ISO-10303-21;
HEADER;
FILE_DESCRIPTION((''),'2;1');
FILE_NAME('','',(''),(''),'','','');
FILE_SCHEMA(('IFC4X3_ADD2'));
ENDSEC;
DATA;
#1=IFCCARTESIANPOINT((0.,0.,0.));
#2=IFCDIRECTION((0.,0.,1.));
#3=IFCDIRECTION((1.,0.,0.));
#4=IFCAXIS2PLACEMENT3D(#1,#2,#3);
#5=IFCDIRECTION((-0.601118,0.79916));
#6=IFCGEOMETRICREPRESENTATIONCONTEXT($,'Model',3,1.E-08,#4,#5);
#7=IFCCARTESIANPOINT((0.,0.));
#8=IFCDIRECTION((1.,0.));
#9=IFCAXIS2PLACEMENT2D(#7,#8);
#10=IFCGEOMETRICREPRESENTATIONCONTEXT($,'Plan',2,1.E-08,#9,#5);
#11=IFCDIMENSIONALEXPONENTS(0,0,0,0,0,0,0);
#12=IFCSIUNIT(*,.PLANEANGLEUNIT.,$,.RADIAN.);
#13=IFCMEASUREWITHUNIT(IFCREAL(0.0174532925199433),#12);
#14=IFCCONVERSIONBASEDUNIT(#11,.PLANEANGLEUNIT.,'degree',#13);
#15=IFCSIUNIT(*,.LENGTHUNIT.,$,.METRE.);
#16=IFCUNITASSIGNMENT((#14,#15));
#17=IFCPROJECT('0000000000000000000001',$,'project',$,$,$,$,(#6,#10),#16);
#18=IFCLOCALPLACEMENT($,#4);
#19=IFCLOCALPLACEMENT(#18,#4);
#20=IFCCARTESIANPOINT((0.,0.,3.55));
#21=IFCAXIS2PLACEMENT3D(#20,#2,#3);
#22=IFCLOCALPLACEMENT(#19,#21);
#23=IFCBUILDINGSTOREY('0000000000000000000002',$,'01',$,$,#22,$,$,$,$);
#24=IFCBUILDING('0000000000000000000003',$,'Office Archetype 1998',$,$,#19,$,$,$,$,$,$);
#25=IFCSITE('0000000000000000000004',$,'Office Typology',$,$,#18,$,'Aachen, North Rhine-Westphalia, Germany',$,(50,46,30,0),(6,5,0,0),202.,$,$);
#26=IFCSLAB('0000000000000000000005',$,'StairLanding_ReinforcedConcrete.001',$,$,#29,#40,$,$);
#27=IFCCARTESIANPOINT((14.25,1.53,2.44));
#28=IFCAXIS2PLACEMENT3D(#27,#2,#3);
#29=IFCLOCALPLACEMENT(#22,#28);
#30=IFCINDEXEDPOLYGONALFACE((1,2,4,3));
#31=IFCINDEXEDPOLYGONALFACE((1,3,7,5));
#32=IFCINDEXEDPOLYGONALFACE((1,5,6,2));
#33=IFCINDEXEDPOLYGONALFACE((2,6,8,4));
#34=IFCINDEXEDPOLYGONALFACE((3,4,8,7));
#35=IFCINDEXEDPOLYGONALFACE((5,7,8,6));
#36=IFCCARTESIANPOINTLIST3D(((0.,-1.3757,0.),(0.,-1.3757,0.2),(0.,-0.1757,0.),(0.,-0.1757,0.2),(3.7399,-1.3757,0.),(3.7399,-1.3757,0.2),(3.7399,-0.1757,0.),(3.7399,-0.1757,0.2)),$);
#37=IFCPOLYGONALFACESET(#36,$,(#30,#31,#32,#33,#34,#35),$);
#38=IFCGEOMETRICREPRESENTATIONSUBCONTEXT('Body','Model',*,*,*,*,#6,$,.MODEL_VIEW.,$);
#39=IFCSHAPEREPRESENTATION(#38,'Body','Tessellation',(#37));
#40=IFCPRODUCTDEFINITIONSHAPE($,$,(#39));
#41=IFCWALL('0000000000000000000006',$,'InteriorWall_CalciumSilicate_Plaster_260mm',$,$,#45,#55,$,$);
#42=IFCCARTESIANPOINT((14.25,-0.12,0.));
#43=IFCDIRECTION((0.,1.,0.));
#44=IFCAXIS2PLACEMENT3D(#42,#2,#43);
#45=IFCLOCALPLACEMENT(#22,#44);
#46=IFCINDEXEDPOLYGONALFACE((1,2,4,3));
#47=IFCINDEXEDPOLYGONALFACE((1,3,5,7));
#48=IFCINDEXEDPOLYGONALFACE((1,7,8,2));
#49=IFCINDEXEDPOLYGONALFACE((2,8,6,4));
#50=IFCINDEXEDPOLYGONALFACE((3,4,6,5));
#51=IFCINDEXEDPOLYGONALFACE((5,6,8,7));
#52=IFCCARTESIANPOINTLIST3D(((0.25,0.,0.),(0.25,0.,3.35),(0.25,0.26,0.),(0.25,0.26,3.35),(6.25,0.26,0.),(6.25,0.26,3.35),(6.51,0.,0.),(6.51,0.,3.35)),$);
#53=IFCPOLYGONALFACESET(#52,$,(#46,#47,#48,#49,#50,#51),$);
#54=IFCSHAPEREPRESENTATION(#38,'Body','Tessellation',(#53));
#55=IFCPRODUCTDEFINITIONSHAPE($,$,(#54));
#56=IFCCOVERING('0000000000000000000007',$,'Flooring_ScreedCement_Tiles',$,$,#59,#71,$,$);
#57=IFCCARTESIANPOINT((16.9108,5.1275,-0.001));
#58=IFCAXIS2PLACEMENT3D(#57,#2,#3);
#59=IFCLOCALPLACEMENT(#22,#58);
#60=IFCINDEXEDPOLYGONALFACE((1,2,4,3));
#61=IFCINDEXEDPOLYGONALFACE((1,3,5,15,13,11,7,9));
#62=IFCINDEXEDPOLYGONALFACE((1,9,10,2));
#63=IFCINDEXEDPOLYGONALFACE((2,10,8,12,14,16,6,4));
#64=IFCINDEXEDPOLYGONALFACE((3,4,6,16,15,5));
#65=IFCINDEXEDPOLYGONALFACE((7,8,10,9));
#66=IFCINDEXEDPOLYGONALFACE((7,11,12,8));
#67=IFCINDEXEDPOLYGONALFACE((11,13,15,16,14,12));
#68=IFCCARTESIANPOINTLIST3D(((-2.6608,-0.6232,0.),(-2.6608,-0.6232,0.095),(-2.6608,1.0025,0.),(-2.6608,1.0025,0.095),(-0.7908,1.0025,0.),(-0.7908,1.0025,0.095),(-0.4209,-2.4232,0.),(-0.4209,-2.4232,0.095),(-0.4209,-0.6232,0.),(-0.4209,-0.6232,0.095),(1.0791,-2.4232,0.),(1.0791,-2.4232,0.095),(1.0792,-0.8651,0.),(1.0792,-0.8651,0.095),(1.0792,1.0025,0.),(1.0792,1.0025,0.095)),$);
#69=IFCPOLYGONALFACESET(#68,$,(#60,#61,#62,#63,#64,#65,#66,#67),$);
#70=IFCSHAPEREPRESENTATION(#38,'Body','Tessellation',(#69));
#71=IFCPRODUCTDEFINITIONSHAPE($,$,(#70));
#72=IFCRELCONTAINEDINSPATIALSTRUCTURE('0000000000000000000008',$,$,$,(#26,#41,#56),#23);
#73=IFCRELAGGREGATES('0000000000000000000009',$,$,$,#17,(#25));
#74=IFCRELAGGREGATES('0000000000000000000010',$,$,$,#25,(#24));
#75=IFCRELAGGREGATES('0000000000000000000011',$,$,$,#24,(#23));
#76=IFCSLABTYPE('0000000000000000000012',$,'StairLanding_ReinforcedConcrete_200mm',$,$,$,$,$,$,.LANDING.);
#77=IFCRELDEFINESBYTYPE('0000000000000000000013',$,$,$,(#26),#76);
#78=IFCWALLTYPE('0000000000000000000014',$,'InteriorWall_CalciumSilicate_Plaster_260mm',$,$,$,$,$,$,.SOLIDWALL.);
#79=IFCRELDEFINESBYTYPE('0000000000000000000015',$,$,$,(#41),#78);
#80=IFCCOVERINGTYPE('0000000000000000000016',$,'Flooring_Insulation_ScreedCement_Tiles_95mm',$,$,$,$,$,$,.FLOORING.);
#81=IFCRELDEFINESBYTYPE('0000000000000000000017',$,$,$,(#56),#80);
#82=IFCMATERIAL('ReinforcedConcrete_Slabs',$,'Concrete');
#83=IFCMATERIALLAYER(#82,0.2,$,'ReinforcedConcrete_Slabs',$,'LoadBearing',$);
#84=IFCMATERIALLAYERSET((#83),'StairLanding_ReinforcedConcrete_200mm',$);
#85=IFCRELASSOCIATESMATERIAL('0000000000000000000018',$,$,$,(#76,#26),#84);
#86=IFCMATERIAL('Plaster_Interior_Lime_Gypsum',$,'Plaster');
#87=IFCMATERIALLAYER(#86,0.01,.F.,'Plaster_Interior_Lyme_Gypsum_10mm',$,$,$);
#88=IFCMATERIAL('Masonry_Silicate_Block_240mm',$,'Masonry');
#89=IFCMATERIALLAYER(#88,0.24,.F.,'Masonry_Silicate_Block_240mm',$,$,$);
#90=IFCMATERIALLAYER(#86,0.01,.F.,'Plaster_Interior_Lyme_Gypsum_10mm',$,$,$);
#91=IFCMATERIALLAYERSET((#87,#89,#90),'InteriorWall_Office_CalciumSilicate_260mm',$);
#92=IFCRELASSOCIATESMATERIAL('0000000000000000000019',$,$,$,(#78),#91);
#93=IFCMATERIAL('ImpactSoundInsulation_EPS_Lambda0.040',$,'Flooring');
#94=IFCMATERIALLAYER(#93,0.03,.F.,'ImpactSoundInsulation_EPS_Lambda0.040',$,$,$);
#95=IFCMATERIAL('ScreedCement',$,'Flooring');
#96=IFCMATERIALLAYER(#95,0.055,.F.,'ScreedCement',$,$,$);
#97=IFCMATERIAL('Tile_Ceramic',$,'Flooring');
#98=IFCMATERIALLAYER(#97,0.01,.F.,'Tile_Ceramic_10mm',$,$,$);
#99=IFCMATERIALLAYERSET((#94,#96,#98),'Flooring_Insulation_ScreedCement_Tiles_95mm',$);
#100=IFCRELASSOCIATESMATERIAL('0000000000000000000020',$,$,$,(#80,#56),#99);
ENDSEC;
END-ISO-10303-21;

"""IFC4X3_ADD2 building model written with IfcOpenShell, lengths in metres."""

from ifc_helpers import new_model, entity, si_unit, converted_unit, direction, frame, origin_with_axes, origin_2d_with_axis, place, context, subcontext, project, spatial, line, indexed_curve, outline, extrude, material, layer, layer_set, layer_usage, type_object, element, save


model = new_model("IFC4X3_ADD2")

# Units and contexts
model_context = context("Model", 3, precision=1e-08, world=origin_with_axes(), true_north=direction((-0.601118, 0.79916)))
plan_context = context("Plan", 2, precision=1e-08, world=origin_2d_with_axis(), true_north=direction((-0.601118, 0.79916)))
body_context = subcontext(model_context, "Body", "Model", "MODEL_VIEW")
ifc_project = project(units=[converted_unit("PLANEANGLEUNIT", "degree", entity("IfcReal", 0.0174532925199433), si_unit("PLANEANGLEUNIT", "RADIAN"), dimensions=[0, 0, 0, 0, 0, 0, 0]), si_unit("LENGTHUNIT", "METRE")], contexts=[model_context, plan_context])

# Site, building, storey
site_placement = place(None, origin_with_axes())
site = spatial("IfcSite", under=ifc_project, at=site_placement, Name="Office Typology", LongName="Aachen, North Rhine-Westphalia, Germany", RefLatitude=(50, 46, 30, 0), RefLongitude=(6, 5, 0, 0), RefElevation=202.0)
building_placement = place(site_placement, origin_with_axes())
building = spatial("IfcBuilding", under=site, at=building_placement, Name="Office Archetype 1998")
storey_placement = place(building_placement, frame((0.0, 0.0, 3.55), z_axis=(0.0, 0.0, 1.0), x_axis=(1.0, 0.0, 0.0)))
storey = spatial("IfcBuildingStorey", under=building, at=storey_placement, Name="01")

# Slab
ifc_material_1 = material(Name="ReinforcedConcrete_Slabs", Category="Concrete")
ifc_layer_1 = layer(ifc_material_1, 0.2, Name="ReinforcedConcrete_Slabs", Category="LoadBearing")
ifc_layer_set_1 = layer_set([ifc_layer_1], Name="StairLanding_ReinforcedConcrete_200mm")
ifc_layer_usage_1 = layer_usage(ifc_layer_set_1, "AXIS3", "POSITIVE", 0.0)
slab_type_1 = type_object("IfcSlabType", Name="StairLanding_ReinforcedConcrete_200mm", PredefinedType="LANDING", material=ifc_layer_set_1)
slab_1_placement = place(storey_placement, frame((14.25, 1.53, 2.44), z_axis=(0.0, 0.0, 1.0), x_axis=(1.0, 0.0, 0.0)))
element("IfcSlab", 1, at=slab_1_placement, inside=storey, type_object=slab_type_1, material=ifc_layer_usage_1, Name="StairLanding_ReinforcedConcrete.001", context=body_context, shape_type="SweptSolid", body=[
    extrude(outline(indexed_curve([(3.7399, -0.1757), (3.7399, -1.3757), (0.0, -1.3757), (0.0, -0.1757), (3.7399, -0.1757)])), None, (0.0, 0.0, 1.0), 0.2),
])

# Wall
ifc_material_2 = material(Name="Plaster_Interior_Lime_Gypsum", Category="Plaster")
ifc_layer_2 = layer(ifc_material_2, 0.01, ventilated=False, Name="Plaster_Interior_Lyme_Gypsum_10mm")
ifc_material_3 = material(Name="Masonry_Silicate_Block_240mm", Category="Masonry")
ifc_layer_3 = layer(ifc_material_3, 0.24, ventilated=False, Name="Masonry_Silicate_Block_240mm")
ifc_layer_4 = layer(ifc_material_2, 0.01, ventilated=False, Name="Plaster_Interior_Lyme_Gypsum_10mm")
ifc_layer_set_2 = layer_set([ifc_layer_2, ifc_layer_3, ifc_layer_4], Name="InteriorWall_Office_CalciumSilicate_260mm")
wall_type = type_object("IfcWallType", Name="InteriorWall_CalciumSilicate_Plaster_260mm", PredefinedType="SOLIDWALL", material=ifc_layer_set_2)
wall_placement = place(storey_placement, frame((14.25, -0.12, 0.0), z_axis=(0.0, 0.0, 1.0), x_axis=(0.0, 1.0, 0.0)))
element("IfcWall", 2, at=wall_placement, inside=storey, type_object=wall_type, Name="InteriorWall_CalciumSilicate_Plaster_260mm", context=body_context, shape_type="SweptSolid", body=[
    extrude(outline(indexed_curve([(0.25, 0.0), (0.25, 0.26), (6.25, 0.26), (6.51, 0.0)], segments=[line(1, 2, 3, 4, 1)])), origin_with_axes(), (0.0, 0.0, 1.0), 3.35),
])

# Covering
ifc_material_4 = material(Name="ImpactSoundInsulation_EPS_Lambda0.040", Category="Flooring")
ifc_layer_5 = layer(ifc_material_4, 0.03, ventilated=False, Name="ImpactSoundInsulation_EPS_Lambda0.040")
ifc_material_5 = material(Name="ScreedCement", Category="Flooring")
ifc_layer_6 = layer(ifc_material_5, 0.055, ventilated=False, Name="ScreedCement")
ifc_material_6 = material(Name="Tile_Ceramic", Category="Flooring")
ifc_layer_7 = layer(ifc_material_6, 0.01, ventilated=False, Name="Tile_Ceramic_10mm")
ifc_layer_set_3 = layer_set([ifc_layer_5, ifc_layer_6, ifc_layer_7], Name="Flooring_Insulation_ScreedCement_Tiles_95mm")
ifc_layer_usage_2 = layer_usage(ifc_layer_set_3, "AXIS3", "POSITIVE", 0.0)
covering_type = type_object("IfcCoveringType", Name="Flooring_Insulation_ScreedCement_Tiles_95mm", PredefinedType="FLOORING", material=ifc_layer_set_3)
covering_placement = place(storey_placement, frame((16.9108, 5.1275, -0.001), z_axis=(0.0, 0.0, 1.0), x_axis=(1.0, 0.0, 0.0)))
element("IfcCovering", 3, at=covering_placement, inside=storey, type_object=covering_type, material=ifc_layer_usage_2, Name="Flooring_ScreedCement_Tiles", context=body_context, shape_type="SweptSolid", body=[
    extrude(outline(indexed_curve([(-0.7908, 1.0025), (-2.6608, 1.0025), (-2.6608, -0.6232), (-0.4209, -0.6232), (-0.4209, -2.4232), (1.0791, -2.4232), (1.0792, -0.8651), (1.0792, 1.0025), (-0.7908, 1.0025)])), None, (0.0, 0.0, 1.0), 0.095),
])

save(model, "model.ifc")
